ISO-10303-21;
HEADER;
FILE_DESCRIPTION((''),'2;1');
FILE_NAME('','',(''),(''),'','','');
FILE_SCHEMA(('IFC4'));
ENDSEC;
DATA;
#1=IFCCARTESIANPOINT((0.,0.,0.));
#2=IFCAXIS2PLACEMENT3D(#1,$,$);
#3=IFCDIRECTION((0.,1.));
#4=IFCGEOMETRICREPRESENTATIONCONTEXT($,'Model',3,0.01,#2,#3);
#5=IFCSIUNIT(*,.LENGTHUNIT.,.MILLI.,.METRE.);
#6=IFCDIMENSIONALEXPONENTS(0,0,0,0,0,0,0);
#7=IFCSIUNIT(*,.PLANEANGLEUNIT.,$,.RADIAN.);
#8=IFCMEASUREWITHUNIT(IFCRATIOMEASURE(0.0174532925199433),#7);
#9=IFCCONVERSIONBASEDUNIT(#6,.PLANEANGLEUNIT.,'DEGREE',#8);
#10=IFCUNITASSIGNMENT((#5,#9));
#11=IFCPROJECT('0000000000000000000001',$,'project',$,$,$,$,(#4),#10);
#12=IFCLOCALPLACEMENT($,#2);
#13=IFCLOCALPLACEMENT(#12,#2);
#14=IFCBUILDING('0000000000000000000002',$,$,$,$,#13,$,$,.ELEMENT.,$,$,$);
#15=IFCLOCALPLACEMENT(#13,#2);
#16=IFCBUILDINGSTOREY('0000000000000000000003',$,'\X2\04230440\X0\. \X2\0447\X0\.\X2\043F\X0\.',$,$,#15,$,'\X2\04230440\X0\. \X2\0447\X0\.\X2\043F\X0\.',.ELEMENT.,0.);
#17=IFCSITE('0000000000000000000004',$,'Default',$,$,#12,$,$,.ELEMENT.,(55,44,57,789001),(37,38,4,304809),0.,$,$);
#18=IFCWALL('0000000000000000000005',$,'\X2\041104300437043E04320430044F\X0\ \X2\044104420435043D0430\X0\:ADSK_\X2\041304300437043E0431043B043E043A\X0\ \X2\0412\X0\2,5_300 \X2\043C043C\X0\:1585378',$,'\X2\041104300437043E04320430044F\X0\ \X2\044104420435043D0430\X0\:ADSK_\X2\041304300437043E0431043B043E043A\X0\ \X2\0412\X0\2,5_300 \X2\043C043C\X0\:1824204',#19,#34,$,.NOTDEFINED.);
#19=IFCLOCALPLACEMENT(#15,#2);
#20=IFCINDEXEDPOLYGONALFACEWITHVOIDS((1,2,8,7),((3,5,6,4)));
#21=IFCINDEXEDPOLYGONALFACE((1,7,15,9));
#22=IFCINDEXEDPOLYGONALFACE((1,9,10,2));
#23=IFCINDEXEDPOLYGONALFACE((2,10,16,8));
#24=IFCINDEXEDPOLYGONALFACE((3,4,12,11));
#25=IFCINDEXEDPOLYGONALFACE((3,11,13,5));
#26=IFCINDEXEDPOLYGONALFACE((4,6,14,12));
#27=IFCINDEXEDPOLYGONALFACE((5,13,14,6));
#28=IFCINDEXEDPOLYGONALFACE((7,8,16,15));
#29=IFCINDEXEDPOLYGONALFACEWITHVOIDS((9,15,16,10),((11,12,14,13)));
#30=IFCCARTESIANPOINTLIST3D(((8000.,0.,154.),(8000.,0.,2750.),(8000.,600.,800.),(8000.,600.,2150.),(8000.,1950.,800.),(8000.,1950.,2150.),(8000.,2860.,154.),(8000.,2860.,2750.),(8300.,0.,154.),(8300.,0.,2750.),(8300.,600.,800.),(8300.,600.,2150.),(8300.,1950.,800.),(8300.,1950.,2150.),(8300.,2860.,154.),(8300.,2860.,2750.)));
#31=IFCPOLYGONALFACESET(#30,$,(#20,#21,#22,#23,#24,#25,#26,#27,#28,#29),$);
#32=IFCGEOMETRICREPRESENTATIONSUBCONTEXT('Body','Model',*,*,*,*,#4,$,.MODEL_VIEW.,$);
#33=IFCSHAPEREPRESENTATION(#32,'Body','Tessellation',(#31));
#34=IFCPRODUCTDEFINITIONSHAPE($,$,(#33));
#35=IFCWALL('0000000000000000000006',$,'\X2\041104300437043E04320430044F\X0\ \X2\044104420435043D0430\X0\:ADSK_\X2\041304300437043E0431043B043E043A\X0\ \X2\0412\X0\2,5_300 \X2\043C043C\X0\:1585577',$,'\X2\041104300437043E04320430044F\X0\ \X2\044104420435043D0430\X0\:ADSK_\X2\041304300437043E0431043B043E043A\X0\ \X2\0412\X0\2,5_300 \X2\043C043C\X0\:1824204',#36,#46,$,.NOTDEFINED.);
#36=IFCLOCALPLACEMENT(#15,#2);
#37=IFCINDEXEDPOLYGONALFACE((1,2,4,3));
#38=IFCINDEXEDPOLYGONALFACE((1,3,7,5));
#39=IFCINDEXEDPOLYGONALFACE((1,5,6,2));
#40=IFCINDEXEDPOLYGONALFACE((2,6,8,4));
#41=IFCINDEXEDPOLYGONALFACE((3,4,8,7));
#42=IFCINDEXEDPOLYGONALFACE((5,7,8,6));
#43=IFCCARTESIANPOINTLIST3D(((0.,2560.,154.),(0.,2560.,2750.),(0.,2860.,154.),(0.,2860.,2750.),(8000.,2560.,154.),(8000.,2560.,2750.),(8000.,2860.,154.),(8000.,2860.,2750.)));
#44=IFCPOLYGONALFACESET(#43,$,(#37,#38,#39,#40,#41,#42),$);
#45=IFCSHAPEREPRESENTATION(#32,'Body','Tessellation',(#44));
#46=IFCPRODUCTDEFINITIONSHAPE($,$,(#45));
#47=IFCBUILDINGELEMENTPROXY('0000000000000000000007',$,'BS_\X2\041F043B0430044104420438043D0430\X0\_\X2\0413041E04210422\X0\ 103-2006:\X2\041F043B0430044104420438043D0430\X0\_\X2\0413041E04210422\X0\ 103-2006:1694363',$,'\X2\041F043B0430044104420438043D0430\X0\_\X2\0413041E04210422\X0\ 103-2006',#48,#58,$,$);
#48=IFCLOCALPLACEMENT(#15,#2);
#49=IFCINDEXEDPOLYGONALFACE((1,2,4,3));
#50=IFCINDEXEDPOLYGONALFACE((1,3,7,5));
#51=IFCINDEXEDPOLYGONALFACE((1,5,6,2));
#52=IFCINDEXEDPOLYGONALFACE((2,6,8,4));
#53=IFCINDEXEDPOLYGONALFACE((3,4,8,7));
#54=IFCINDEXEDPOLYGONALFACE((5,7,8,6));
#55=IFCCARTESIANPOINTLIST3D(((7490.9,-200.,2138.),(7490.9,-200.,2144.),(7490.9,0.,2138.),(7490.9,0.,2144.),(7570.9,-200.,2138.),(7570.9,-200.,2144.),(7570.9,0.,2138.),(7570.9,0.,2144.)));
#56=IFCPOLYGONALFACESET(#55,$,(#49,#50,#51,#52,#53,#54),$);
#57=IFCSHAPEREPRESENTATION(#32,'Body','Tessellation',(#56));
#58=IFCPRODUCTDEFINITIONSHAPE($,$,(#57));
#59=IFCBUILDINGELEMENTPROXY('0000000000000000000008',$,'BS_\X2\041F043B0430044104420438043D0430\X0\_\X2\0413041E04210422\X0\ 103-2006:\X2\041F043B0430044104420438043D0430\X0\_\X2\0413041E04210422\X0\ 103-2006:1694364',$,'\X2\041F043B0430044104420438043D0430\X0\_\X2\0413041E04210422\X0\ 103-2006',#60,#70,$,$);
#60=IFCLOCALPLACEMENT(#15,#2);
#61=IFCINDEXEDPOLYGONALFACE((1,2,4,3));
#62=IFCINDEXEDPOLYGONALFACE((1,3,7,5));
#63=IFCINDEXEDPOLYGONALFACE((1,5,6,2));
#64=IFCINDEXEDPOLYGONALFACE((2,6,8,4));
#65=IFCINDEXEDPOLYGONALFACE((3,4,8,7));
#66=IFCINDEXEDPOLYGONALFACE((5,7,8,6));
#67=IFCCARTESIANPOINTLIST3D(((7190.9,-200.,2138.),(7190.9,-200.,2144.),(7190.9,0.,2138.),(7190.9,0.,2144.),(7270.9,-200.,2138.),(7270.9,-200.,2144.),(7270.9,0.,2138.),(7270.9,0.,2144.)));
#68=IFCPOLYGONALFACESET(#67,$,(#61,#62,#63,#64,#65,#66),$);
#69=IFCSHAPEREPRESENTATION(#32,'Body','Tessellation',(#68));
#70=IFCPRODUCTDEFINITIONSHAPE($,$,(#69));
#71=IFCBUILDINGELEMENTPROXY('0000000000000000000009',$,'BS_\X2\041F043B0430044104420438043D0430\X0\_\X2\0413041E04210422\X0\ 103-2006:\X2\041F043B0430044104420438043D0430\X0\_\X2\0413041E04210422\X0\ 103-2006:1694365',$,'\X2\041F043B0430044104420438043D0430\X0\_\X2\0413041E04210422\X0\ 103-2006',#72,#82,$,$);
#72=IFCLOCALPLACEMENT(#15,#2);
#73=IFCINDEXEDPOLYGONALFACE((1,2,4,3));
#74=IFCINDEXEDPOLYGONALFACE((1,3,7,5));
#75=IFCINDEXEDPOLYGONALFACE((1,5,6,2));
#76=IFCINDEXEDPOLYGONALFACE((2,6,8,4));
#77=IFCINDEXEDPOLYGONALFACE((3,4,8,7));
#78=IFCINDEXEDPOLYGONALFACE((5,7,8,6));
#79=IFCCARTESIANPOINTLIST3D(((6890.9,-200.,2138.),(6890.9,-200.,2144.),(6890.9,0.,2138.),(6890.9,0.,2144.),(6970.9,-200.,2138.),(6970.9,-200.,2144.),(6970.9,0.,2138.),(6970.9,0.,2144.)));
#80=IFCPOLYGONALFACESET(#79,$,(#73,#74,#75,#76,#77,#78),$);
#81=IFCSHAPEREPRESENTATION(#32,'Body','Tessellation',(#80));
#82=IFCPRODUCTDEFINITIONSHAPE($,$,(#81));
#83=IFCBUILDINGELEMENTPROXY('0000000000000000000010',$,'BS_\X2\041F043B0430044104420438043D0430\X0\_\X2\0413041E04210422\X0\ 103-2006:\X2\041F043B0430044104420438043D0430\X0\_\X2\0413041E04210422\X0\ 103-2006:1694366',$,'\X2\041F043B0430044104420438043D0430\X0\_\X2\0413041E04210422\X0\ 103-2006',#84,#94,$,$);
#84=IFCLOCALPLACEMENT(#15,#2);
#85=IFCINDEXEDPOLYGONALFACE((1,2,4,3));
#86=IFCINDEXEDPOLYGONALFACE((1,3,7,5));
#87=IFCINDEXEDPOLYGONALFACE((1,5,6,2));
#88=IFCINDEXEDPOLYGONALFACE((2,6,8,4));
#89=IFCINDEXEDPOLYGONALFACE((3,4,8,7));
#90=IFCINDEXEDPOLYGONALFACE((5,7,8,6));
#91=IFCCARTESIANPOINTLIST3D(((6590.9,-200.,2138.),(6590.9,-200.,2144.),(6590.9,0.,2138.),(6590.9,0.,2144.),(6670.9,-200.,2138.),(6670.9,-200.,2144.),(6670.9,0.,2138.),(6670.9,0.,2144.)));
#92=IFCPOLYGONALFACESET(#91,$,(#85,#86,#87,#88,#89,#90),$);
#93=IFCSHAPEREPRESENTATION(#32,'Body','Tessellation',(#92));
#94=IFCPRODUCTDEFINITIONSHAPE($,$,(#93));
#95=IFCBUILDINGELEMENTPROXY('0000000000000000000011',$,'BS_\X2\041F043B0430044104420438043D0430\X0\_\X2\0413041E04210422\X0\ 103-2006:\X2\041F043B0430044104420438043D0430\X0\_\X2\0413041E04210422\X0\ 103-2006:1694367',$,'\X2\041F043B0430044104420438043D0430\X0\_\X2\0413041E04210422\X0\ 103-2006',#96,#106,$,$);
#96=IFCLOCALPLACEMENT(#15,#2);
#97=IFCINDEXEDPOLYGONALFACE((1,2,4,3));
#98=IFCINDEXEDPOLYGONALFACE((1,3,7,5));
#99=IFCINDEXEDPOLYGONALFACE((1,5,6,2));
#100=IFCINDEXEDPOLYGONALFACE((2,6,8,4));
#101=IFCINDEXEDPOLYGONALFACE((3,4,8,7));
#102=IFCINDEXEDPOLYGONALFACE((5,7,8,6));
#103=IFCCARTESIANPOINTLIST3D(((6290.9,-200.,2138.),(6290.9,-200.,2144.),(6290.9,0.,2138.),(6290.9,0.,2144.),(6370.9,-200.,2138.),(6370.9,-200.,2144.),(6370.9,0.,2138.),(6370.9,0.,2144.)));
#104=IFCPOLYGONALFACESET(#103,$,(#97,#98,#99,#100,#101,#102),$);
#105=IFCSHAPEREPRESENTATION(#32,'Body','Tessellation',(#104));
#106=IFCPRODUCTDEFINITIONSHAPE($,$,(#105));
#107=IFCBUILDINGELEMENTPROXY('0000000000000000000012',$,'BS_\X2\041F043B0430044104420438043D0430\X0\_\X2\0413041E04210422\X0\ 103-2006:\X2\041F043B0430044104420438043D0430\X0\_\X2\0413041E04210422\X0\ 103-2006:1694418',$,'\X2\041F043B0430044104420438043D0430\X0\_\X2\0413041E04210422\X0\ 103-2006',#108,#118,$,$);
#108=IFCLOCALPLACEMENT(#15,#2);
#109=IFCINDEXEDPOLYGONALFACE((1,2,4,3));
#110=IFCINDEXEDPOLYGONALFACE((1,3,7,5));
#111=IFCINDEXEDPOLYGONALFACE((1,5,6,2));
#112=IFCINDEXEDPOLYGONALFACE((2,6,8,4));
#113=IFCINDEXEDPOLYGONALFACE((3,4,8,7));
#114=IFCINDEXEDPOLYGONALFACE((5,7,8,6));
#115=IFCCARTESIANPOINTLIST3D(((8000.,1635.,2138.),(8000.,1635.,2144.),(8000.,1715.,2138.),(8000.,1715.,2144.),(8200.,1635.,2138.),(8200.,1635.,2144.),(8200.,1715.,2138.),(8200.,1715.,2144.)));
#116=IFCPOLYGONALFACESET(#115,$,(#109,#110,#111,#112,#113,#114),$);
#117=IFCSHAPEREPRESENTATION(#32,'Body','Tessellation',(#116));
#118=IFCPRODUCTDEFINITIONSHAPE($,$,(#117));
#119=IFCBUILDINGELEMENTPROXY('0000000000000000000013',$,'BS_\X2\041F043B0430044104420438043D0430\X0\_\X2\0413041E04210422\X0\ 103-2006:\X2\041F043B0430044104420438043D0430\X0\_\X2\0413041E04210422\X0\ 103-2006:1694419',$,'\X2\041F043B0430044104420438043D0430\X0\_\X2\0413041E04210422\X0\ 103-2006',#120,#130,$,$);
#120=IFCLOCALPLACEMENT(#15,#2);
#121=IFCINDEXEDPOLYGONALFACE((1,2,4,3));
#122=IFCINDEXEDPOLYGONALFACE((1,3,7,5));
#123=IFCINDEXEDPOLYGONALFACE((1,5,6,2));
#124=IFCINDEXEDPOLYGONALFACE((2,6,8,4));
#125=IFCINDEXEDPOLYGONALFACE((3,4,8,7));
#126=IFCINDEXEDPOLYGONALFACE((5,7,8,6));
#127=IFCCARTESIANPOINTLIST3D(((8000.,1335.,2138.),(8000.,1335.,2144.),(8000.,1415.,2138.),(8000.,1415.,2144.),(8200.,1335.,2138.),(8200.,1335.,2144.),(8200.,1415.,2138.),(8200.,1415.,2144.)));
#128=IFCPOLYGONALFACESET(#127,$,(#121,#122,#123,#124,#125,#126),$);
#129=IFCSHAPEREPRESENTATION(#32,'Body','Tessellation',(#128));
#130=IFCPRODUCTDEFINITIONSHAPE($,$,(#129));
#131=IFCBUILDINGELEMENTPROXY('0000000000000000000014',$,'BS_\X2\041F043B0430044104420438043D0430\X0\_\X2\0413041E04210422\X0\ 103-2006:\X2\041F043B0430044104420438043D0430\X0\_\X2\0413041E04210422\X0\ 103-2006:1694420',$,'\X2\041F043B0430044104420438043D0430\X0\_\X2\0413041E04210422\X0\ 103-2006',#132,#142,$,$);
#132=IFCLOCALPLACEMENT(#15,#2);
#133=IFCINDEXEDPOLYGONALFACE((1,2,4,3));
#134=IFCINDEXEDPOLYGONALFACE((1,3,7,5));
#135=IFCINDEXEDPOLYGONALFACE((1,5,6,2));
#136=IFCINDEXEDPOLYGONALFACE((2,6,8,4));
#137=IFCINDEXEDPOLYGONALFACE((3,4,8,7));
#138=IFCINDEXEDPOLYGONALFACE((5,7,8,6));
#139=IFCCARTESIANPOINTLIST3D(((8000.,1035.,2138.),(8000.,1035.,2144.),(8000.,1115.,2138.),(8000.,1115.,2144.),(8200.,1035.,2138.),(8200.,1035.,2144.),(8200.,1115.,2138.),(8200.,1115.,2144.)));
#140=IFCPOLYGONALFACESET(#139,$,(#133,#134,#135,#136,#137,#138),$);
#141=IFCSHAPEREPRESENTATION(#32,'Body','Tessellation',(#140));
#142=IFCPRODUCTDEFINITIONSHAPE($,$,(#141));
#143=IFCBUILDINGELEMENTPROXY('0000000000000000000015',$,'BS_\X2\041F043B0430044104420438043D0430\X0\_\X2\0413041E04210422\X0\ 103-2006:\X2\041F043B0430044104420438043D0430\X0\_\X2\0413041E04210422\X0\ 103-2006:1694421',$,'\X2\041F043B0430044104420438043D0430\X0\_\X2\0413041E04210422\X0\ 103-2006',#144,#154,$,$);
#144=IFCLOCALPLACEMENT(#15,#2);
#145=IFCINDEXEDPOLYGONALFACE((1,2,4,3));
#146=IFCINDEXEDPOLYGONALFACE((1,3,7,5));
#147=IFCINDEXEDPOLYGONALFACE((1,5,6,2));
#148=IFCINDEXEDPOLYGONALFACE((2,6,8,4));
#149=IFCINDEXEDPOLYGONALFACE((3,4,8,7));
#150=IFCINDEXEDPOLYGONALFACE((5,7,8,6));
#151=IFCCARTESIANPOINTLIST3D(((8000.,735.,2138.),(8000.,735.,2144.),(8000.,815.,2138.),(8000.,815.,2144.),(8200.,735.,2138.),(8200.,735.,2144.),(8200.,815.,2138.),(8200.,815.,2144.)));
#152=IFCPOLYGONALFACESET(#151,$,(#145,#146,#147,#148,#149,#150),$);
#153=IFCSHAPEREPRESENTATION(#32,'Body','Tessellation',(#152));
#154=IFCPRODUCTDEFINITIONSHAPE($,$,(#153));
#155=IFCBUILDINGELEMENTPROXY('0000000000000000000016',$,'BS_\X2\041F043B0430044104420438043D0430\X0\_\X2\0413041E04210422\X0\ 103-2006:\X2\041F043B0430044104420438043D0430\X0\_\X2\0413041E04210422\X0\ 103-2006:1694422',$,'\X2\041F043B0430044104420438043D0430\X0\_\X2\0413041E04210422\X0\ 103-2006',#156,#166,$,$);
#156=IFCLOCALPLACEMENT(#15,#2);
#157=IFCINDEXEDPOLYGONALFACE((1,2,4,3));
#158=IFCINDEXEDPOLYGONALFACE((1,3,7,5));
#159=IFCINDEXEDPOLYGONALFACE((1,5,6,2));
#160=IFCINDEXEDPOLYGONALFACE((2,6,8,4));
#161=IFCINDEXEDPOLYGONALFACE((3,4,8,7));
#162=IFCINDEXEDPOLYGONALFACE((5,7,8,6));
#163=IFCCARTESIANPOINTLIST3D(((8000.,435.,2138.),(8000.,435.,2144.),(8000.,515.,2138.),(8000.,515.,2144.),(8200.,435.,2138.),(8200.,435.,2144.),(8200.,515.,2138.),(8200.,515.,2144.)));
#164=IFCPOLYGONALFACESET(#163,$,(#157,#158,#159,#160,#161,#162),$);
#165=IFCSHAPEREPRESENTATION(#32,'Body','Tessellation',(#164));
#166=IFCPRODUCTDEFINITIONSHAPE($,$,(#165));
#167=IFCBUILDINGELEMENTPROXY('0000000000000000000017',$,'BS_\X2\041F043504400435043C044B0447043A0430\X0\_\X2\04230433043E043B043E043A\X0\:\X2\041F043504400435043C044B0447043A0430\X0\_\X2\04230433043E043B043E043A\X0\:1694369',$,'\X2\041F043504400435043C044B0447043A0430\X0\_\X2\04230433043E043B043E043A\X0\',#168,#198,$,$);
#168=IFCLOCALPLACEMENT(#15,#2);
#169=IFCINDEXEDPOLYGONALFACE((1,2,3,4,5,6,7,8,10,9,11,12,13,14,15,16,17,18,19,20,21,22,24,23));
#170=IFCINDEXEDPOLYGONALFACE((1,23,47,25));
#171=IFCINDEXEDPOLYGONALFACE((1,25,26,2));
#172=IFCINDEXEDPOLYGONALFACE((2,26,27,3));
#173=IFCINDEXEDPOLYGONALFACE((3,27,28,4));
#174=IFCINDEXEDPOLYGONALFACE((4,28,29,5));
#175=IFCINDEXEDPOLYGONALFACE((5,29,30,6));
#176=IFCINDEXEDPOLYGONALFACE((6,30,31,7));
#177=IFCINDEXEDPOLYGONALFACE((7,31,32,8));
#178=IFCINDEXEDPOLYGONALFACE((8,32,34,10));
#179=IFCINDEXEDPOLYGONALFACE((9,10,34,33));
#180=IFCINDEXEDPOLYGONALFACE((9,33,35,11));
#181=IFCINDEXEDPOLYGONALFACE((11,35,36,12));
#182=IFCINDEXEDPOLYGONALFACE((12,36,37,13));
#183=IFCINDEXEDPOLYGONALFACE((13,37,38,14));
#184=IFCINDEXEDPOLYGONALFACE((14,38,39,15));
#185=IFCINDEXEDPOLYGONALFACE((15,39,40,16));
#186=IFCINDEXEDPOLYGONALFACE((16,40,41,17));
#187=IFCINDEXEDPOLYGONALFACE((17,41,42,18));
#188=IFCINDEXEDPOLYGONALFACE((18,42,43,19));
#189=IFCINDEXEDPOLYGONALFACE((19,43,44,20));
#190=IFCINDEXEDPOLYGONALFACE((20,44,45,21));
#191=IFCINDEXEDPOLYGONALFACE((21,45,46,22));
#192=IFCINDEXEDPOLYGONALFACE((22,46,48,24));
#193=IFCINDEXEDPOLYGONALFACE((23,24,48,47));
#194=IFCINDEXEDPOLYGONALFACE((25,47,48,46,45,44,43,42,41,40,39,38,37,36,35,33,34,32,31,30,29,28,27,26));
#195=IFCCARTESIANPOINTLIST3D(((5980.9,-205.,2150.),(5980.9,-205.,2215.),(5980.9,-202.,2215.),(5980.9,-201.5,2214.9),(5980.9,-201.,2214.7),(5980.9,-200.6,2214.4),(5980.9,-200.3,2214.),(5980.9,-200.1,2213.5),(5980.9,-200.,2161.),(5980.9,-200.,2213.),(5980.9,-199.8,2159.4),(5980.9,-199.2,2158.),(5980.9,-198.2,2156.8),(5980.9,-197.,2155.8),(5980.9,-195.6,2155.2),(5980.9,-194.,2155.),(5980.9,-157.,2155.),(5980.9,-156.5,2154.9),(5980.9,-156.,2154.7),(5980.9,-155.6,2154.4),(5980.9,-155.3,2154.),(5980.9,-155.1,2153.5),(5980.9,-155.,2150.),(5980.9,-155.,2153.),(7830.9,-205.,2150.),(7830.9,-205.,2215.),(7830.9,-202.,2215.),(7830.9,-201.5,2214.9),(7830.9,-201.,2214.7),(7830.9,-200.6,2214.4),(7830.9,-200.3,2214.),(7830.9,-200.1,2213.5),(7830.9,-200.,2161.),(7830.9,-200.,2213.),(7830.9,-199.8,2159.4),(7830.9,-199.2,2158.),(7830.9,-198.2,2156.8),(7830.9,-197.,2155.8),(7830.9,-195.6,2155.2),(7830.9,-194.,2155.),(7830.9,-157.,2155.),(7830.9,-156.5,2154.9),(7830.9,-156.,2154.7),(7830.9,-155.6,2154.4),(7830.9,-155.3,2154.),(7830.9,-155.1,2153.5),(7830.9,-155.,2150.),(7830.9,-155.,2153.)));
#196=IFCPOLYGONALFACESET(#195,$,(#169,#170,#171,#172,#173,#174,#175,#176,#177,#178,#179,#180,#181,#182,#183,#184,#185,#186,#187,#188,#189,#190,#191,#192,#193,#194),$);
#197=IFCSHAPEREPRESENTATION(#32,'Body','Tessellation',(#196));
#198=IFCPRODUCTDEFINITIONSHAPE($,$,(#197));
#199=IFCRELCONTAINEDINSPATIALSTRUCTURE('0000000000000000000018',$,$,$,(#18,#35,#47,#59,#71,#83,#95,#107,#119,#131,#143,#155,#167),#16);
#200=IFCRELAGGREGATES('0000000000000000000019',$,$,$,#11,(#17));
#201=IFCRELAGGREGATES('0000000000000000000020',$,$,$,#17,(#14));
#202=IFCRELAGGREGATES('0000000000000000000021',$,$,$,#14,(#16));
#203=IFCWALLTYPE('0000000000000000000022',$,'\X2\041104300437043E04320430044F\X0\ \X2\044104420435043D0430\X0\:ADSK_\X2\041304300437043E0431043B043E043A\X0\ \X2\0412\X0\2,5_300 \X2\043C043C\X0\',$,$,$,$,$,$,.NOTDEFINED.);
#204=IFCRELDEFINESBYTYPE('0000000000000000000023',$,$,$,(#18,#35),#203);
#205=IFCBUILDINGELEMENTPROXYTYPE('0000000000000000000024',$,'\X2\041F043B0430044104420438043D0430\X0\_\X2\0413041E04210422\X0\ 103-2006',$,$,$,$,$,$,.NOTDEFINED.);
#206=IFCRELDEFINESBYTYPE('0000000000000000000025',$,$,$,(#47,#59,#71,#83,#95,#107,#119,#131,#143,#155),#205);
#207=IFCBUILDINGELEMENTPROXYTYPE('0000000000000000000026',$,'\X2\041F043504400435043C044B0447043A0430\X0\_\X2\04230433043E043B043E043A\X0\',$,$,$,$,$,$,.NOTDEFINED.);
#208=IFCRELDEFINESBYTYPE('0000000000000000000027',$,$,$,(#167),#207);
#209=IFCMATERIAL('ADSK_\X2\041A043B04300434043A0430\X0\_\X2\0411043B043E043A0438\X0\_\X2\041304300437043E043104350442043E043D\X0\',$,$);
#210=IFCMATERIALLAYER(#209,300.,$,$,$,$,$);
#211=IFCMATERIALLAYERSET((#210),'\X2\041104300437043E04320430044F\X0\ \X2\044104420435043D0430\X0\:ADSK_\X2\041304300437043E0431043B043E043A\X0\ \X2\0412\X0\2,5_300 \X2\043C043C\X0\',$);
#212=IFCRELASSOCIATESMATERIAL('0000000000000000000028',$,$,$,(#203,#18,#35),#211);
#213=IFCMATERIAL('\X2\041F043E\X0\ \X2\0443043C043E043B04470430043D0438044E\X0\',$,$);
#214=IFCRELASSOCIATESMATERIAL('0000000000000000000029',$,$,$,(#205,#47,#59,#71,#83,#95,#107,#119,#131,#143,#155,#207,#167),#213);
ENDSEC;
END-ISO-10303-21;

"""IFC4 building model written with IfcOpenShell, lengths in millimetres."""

from ifc_helpers import new_model, entity, si_unit, converted_unit, direction, frame, frame_2d, origin, origin_2d_with_axis, place, context, subcontext, project, spatial, polyline, circle_curve, parameter, trimmed, segment, composite_curve, rectangle, outline, extrude, source, transform, mapped, material, layer, layer_set, layer_usage, type_object, type_shapes, element, save


model = new_model("IFC4")

# Units and contexts
model_context = context("Model", 3, precision=0.01, world=origin(), true_north=direction((0.0, 1.0)))
body_context = subcontext(model_context, "Body", "Model", "MODEL_VIEW")
ifc_project = project(units=[si_unit("LENGTHUNIT", "METRE", prefix="MILLI"), converted_unit("PLANEANGLEUNIT", "DEGREE", entity("IfcRatioMeasure", 0.0174532925199433), si_unit("PLANEANGLEUNIT", "RADIAN"), dimensions=[0, 0, 0, 0, 0, 0, 0])], contexts=[model_context])

# Site, building, storey
site_placement = place(None, origin())
site = spatial("IfcSite", under=ifc_project, at=site_placement, Name="Default", CompositionType="ELEMENT", RefLatitude=(55, 44, 57, 789001), RefLongitude=(37, 38, 4, 304809), RefElevation=0.0)
building_placement = place(site_placement, origin())
building = spatial("IfcBuilding", under=site, at=building_placement, CompositionType="ELEMENT")
storey_placement = place(building_placement, origin())
storey = spatial("IfcBuildingStorey", under=building, at=storey_placement, Name="Ур. ч.п.", LongName="Ур. ч.п.", CompositionType="ELEMENT", Elevation=0.0)

# Wall, opening
ifc_material_1 = material(Name="ADSK_Кладка_Блоки_Газобетон")
ifc_layer = layer(ifc_material_1, 300.0)
ifc_layer_set = layer_set([ifc_layer], Name="Базовая стена:ADSK_Газоблок В2,5_300 мм")
ifc_layer_usage_1 = layer_usage(ifc_layer_set, "AXIS2", "POSITIVE", -150.0)
wall_type = type_object("IfcWallType", Name="Базовая стена:ADSK_Газоблок В2,5_300 мм", PredefinedType="NOTDEFINED", material=ifc_layer_set)
wall_1_placement = place(storey_placement, frame((8150.0, 0.0, 154.0), z_axis=(0.0, 0.0, 1.0), x_axis=(0.0, 1.0, 0.0)))
wall_1 = element("IfcWall", 1, at=wall_1_placement, inside=storey, type_object=wall_type, material=ifc_layer_usage_1, Name="Базовая стена:ADSK_Газоблок В2,5_300 мм:1585378", ObjectType="Базовая стена:ADSK_Газоблок В2,5_300 мм:1824204", PredefinedType="NOTDEFINED", context=body_context, shape_type="SweptSolid", body=[
    extrude(rectangle(XDim=2860.0, YDim=300.0, at=frame_2d((1430.0, 0.0), x_axis=(-1.0, 0.0))), origin(), (0.0, 0.0, 1.0), 2596.0),
])
opening_placement = place(wall_1_placement, frame((600.0, 1674.0, 646.0), z_axis=(0.0, 0.0, 1.0), x_axis=(0.0, -1.0, 0.0)))
element("IfcOpeningElement", 2, at=opening_placement, cuts=wall_1, ObjectType="Opening", PredefinedType="OPENING", context=body_context, shape_type="SweptSolid", body=[
    extrude(rectangle(XDim=1350.0, YDim=1350.0, at=frame_2d((0.0, 0.0), x_axis=(0.0, 1.0))), frame((3048.0, 675.0, 675.0), z_axis=(-1.0, 0.0, 0.0), x_axis=(0.0, 1.0, 0.0)), (0.0, 0.0, 1.0), 3048.0),
])

# Wall
ifc_layer_usage_2 = layer_usage(ifc_layer_set, "AXIS2", "POSITIVE", -150.0)
wall_2_placement = place(storey_placement, frame((8000.0, 2710.0, 154.0), z_axis=(0.0, 0.0, 1.0), x_axis=(-1.0, 0.0, 0.0)))
element("IfcWall", 3, at=wall_2_placement, inside=storey, type_object=wall_type, material=ifc_layer_usage_2, Name="Базовая стена:ADSK_Газоблок В2,5_300 мм:1585577", ObjectType="Базовая стена:ADSK_Газоблок В2,5_300 мм:1824204", PredefinedType="NOTDEFINED", context=body_context, shape_type="SweptSolid", body=[
    extrude(rectangle(XDim=8000.0, YDim=300.0, at=frame_2d((4000.0, 0.0), x_axis=(-1.0, 0.0))), origin(), (0.0, 0.0, 1.0), 2596.0),
])

# Building element proxies
ifc_material_2 = material(Name="По умолчанию")
building_element_proxy_type_1 = type_object("IfcBuildingElementProxyType", Name="Пластина_ГОСТ 103-2006", material=ifc_material_2)
shared_shape_1 = source(origin(), body_context, "Body", "SweptSolid", [
    extrude(rectangle(XDim=200.0, YDim=80.0, at=origin_2d_with_axis()), frame((0.0, 0.0, 0.0), z_axis=(0.0, 0.0, 1.0), x_axis=(-1.0, 0.0, 0.0)), (0.0, 0.0, 1.0), 6.0),
])
type_shapes(building_element_proxy_type_1, [shared_shape_1])
for number, where, z_axis, x_axis, name in (
    (4, (7530.9, -100.0, 2138.0), (0.0, 0.0, 1.0), (0.0, 1.0, 0.0), "BS_Пластина_ГОСТ 103-2006:Пластина_ГОСТ 103-2006:1694363"),
    (5, (7230.9, -100.0, 2138.0), (0.0, 0.0, 1.0), (0.0, 1.0, 0.0), "BS_Пластина_ГОСТ 103-2006:Пластина_ГОСТ 103-2006:1694364"),
    (6, (6930.9, -100.0, 2138.0), (0.0, 0.0, 1.0), (0.0, 1.0, 0.0), "BS_Пластина_ГОСТ 103-2006:Пластина_ГОСТ 103-2006:1694365"),
    (7, (6630.9, -100.0, 2138.0), (0.0, 0.0, 1.0), (0.0, 1.0, 0.0), "BS_Пластина_ГОСТ 103-2006:Пластина_ГОСТ 103-2006:1694366"),
    (8, (6330.9, -100.0, 2138.0), (0.0, 0.0, 1.0), (0.0, 1.0, 0.0), "BS_Пластина_ГОСТ 103-2006:Пластина_ГОСТ 103-2006:1694367"),
    (9, (8100.0, 1675.0, 2138.0), (0.0, 0.0, 1.0), (-1.0, 0.0, 0.0), "BS_Пластина_ГОСТ 103-2006:Пластина_ГОСТ 103-2006:1694418"),
    (10, (8100.0, 1375.0, 2138.0), (0.0, 0.0, 1.0), (-1.0, 0.0, 0.0), "BS_Пластина_ГОСТ 103-2006:Пластина_ГОСТ 103-2006:1694419"),
    (11, (8100.0, 1075.0, 2138.0), (0.0, 0.0, 1.0), (-1.0, 0.0, 0.0), "BS_Пластина_ГОСТ 103-2006:Пластина_ГОСТ 103-2006:1694420"),
    (12, (8100.0, 775.0, 2138.0), (0.0, 0.0, 1.0), (-1.0, 0.0, 0.0), "BS_Пластина_ГОСТ 103-2006:Пластина_ГОСТ 103-2006:1694421"),
    (13, (8100.0, 475.0, 2138.0), (0.0, 0.0, 1.0), (-1.0, 0.0, 0.0), "BS_Пластина_ГОСТ 103-2006:Пластина_ГОСТ 103-2006:1694422"),
):
    element("IfcBuildingElementProxy", number, at=place(storey_placement, frame(where, z_axis=z_axis, x_axis=x_axis)), inside=storey, type_object=building_element_proxy_type_1, material=ifc_material_2, Name=name, ObjectType="Пластина_ГОСТ 103-2006", context=body_context, shape_type="MappedRepresentation", body=[
        mapped(shared_shape_1, transform((0.0, 0.0, 0.0), scale=1.0)),
    ])
building_element_proxy_type_2 = type_object("IfcBuildingElementProxyType", Name="Перемычка_Уголок", material=ifc_material_2)
shared_shape_2 = source(origin(), body_context, "Body", "SweptSolid", [
    extrude(outline(composite_curve([segment(polyline([(-24.1, -19.1), (40.9, -19.1)]), True, "CONTINUOUS"), segment(polyline([(40.9, -19.1), (40.9, -16.1)]), True, "CONTINUOUS"), segment(trimmed(circle_curve(frame_2d((38.9, -16.1), x_axis=(0.0, 1.0)), 2.0), [parameter(270.0)], [parameter(0.0)], True, "PARAMETER"), True, "CONTINUOUS"), segment(polyline([(38.9, -14.1), (-13.1, -14.1)]), True, "CONTINUOUS"), segment(trimmed(circle_curve(frame_2d((-13.1, -8.1), x_axis=(0.0, 1.0)), 6.0), [parameter(90.0)], [parameter(180.0)], True, "PARAMETER"), False, "CONTINUOUS"), segment(polyline([(-19.1, -8.1), (-19.1, 28.9)]), True, "CONTINUOUS"), segment(trimmed(circle_curve(frame_2d((-21.1, 28.9), x_axis=(0.0, 1.0)), 2.0), [parameter(270.0)], [parameter(0.0)], True, "PARAMETER"), True, "CONTINUOUS"), segment(polyline([(-21.1, 30.9), (-24.1, 30.9)]), True, "CONTINUOUS"), segment(polyline([(-24.1, 30.9), (-24.1, -19.1)]), True, "CONTINUOUS")], self_intersect=False)), frame((0.0, 32.5, 24.1), z_axis=(1.0, 0.0, 0.0), x_axis=(0.0, 0.0, 1.0)), (0.0, 0.0, 1.0), 1850.0),
])
type_shapes(building_element_proxy_type_2, [shared_shape_2])
for number, where, z_axis, x_axis, name in (
    (14, (7830.9, -153.4, 2150.0), (0.0, 0.0, 1.0), (-1.0, 0.0, 0.0), "BS_Перемычка_Уголок:Перемычка_Уголок:1694369"),
):
    element("IfcBuildingElementProxy", number, at=place(storey_placement, frame(where, z_axis=z_axis, x_axis=x_axis)), inside=storey, type_object=building_element_proxy_type_2, material=ifc_material_2, Name=name, ObjectType="Перемычка_Уголок", context=body_context, shape_type="MappedRepresentation", body=[
        mapped(shared_shape_2, transform((0.0, 0.0, 0.0), scale=1.0)),
    ])

save(model, "model.ifc")
